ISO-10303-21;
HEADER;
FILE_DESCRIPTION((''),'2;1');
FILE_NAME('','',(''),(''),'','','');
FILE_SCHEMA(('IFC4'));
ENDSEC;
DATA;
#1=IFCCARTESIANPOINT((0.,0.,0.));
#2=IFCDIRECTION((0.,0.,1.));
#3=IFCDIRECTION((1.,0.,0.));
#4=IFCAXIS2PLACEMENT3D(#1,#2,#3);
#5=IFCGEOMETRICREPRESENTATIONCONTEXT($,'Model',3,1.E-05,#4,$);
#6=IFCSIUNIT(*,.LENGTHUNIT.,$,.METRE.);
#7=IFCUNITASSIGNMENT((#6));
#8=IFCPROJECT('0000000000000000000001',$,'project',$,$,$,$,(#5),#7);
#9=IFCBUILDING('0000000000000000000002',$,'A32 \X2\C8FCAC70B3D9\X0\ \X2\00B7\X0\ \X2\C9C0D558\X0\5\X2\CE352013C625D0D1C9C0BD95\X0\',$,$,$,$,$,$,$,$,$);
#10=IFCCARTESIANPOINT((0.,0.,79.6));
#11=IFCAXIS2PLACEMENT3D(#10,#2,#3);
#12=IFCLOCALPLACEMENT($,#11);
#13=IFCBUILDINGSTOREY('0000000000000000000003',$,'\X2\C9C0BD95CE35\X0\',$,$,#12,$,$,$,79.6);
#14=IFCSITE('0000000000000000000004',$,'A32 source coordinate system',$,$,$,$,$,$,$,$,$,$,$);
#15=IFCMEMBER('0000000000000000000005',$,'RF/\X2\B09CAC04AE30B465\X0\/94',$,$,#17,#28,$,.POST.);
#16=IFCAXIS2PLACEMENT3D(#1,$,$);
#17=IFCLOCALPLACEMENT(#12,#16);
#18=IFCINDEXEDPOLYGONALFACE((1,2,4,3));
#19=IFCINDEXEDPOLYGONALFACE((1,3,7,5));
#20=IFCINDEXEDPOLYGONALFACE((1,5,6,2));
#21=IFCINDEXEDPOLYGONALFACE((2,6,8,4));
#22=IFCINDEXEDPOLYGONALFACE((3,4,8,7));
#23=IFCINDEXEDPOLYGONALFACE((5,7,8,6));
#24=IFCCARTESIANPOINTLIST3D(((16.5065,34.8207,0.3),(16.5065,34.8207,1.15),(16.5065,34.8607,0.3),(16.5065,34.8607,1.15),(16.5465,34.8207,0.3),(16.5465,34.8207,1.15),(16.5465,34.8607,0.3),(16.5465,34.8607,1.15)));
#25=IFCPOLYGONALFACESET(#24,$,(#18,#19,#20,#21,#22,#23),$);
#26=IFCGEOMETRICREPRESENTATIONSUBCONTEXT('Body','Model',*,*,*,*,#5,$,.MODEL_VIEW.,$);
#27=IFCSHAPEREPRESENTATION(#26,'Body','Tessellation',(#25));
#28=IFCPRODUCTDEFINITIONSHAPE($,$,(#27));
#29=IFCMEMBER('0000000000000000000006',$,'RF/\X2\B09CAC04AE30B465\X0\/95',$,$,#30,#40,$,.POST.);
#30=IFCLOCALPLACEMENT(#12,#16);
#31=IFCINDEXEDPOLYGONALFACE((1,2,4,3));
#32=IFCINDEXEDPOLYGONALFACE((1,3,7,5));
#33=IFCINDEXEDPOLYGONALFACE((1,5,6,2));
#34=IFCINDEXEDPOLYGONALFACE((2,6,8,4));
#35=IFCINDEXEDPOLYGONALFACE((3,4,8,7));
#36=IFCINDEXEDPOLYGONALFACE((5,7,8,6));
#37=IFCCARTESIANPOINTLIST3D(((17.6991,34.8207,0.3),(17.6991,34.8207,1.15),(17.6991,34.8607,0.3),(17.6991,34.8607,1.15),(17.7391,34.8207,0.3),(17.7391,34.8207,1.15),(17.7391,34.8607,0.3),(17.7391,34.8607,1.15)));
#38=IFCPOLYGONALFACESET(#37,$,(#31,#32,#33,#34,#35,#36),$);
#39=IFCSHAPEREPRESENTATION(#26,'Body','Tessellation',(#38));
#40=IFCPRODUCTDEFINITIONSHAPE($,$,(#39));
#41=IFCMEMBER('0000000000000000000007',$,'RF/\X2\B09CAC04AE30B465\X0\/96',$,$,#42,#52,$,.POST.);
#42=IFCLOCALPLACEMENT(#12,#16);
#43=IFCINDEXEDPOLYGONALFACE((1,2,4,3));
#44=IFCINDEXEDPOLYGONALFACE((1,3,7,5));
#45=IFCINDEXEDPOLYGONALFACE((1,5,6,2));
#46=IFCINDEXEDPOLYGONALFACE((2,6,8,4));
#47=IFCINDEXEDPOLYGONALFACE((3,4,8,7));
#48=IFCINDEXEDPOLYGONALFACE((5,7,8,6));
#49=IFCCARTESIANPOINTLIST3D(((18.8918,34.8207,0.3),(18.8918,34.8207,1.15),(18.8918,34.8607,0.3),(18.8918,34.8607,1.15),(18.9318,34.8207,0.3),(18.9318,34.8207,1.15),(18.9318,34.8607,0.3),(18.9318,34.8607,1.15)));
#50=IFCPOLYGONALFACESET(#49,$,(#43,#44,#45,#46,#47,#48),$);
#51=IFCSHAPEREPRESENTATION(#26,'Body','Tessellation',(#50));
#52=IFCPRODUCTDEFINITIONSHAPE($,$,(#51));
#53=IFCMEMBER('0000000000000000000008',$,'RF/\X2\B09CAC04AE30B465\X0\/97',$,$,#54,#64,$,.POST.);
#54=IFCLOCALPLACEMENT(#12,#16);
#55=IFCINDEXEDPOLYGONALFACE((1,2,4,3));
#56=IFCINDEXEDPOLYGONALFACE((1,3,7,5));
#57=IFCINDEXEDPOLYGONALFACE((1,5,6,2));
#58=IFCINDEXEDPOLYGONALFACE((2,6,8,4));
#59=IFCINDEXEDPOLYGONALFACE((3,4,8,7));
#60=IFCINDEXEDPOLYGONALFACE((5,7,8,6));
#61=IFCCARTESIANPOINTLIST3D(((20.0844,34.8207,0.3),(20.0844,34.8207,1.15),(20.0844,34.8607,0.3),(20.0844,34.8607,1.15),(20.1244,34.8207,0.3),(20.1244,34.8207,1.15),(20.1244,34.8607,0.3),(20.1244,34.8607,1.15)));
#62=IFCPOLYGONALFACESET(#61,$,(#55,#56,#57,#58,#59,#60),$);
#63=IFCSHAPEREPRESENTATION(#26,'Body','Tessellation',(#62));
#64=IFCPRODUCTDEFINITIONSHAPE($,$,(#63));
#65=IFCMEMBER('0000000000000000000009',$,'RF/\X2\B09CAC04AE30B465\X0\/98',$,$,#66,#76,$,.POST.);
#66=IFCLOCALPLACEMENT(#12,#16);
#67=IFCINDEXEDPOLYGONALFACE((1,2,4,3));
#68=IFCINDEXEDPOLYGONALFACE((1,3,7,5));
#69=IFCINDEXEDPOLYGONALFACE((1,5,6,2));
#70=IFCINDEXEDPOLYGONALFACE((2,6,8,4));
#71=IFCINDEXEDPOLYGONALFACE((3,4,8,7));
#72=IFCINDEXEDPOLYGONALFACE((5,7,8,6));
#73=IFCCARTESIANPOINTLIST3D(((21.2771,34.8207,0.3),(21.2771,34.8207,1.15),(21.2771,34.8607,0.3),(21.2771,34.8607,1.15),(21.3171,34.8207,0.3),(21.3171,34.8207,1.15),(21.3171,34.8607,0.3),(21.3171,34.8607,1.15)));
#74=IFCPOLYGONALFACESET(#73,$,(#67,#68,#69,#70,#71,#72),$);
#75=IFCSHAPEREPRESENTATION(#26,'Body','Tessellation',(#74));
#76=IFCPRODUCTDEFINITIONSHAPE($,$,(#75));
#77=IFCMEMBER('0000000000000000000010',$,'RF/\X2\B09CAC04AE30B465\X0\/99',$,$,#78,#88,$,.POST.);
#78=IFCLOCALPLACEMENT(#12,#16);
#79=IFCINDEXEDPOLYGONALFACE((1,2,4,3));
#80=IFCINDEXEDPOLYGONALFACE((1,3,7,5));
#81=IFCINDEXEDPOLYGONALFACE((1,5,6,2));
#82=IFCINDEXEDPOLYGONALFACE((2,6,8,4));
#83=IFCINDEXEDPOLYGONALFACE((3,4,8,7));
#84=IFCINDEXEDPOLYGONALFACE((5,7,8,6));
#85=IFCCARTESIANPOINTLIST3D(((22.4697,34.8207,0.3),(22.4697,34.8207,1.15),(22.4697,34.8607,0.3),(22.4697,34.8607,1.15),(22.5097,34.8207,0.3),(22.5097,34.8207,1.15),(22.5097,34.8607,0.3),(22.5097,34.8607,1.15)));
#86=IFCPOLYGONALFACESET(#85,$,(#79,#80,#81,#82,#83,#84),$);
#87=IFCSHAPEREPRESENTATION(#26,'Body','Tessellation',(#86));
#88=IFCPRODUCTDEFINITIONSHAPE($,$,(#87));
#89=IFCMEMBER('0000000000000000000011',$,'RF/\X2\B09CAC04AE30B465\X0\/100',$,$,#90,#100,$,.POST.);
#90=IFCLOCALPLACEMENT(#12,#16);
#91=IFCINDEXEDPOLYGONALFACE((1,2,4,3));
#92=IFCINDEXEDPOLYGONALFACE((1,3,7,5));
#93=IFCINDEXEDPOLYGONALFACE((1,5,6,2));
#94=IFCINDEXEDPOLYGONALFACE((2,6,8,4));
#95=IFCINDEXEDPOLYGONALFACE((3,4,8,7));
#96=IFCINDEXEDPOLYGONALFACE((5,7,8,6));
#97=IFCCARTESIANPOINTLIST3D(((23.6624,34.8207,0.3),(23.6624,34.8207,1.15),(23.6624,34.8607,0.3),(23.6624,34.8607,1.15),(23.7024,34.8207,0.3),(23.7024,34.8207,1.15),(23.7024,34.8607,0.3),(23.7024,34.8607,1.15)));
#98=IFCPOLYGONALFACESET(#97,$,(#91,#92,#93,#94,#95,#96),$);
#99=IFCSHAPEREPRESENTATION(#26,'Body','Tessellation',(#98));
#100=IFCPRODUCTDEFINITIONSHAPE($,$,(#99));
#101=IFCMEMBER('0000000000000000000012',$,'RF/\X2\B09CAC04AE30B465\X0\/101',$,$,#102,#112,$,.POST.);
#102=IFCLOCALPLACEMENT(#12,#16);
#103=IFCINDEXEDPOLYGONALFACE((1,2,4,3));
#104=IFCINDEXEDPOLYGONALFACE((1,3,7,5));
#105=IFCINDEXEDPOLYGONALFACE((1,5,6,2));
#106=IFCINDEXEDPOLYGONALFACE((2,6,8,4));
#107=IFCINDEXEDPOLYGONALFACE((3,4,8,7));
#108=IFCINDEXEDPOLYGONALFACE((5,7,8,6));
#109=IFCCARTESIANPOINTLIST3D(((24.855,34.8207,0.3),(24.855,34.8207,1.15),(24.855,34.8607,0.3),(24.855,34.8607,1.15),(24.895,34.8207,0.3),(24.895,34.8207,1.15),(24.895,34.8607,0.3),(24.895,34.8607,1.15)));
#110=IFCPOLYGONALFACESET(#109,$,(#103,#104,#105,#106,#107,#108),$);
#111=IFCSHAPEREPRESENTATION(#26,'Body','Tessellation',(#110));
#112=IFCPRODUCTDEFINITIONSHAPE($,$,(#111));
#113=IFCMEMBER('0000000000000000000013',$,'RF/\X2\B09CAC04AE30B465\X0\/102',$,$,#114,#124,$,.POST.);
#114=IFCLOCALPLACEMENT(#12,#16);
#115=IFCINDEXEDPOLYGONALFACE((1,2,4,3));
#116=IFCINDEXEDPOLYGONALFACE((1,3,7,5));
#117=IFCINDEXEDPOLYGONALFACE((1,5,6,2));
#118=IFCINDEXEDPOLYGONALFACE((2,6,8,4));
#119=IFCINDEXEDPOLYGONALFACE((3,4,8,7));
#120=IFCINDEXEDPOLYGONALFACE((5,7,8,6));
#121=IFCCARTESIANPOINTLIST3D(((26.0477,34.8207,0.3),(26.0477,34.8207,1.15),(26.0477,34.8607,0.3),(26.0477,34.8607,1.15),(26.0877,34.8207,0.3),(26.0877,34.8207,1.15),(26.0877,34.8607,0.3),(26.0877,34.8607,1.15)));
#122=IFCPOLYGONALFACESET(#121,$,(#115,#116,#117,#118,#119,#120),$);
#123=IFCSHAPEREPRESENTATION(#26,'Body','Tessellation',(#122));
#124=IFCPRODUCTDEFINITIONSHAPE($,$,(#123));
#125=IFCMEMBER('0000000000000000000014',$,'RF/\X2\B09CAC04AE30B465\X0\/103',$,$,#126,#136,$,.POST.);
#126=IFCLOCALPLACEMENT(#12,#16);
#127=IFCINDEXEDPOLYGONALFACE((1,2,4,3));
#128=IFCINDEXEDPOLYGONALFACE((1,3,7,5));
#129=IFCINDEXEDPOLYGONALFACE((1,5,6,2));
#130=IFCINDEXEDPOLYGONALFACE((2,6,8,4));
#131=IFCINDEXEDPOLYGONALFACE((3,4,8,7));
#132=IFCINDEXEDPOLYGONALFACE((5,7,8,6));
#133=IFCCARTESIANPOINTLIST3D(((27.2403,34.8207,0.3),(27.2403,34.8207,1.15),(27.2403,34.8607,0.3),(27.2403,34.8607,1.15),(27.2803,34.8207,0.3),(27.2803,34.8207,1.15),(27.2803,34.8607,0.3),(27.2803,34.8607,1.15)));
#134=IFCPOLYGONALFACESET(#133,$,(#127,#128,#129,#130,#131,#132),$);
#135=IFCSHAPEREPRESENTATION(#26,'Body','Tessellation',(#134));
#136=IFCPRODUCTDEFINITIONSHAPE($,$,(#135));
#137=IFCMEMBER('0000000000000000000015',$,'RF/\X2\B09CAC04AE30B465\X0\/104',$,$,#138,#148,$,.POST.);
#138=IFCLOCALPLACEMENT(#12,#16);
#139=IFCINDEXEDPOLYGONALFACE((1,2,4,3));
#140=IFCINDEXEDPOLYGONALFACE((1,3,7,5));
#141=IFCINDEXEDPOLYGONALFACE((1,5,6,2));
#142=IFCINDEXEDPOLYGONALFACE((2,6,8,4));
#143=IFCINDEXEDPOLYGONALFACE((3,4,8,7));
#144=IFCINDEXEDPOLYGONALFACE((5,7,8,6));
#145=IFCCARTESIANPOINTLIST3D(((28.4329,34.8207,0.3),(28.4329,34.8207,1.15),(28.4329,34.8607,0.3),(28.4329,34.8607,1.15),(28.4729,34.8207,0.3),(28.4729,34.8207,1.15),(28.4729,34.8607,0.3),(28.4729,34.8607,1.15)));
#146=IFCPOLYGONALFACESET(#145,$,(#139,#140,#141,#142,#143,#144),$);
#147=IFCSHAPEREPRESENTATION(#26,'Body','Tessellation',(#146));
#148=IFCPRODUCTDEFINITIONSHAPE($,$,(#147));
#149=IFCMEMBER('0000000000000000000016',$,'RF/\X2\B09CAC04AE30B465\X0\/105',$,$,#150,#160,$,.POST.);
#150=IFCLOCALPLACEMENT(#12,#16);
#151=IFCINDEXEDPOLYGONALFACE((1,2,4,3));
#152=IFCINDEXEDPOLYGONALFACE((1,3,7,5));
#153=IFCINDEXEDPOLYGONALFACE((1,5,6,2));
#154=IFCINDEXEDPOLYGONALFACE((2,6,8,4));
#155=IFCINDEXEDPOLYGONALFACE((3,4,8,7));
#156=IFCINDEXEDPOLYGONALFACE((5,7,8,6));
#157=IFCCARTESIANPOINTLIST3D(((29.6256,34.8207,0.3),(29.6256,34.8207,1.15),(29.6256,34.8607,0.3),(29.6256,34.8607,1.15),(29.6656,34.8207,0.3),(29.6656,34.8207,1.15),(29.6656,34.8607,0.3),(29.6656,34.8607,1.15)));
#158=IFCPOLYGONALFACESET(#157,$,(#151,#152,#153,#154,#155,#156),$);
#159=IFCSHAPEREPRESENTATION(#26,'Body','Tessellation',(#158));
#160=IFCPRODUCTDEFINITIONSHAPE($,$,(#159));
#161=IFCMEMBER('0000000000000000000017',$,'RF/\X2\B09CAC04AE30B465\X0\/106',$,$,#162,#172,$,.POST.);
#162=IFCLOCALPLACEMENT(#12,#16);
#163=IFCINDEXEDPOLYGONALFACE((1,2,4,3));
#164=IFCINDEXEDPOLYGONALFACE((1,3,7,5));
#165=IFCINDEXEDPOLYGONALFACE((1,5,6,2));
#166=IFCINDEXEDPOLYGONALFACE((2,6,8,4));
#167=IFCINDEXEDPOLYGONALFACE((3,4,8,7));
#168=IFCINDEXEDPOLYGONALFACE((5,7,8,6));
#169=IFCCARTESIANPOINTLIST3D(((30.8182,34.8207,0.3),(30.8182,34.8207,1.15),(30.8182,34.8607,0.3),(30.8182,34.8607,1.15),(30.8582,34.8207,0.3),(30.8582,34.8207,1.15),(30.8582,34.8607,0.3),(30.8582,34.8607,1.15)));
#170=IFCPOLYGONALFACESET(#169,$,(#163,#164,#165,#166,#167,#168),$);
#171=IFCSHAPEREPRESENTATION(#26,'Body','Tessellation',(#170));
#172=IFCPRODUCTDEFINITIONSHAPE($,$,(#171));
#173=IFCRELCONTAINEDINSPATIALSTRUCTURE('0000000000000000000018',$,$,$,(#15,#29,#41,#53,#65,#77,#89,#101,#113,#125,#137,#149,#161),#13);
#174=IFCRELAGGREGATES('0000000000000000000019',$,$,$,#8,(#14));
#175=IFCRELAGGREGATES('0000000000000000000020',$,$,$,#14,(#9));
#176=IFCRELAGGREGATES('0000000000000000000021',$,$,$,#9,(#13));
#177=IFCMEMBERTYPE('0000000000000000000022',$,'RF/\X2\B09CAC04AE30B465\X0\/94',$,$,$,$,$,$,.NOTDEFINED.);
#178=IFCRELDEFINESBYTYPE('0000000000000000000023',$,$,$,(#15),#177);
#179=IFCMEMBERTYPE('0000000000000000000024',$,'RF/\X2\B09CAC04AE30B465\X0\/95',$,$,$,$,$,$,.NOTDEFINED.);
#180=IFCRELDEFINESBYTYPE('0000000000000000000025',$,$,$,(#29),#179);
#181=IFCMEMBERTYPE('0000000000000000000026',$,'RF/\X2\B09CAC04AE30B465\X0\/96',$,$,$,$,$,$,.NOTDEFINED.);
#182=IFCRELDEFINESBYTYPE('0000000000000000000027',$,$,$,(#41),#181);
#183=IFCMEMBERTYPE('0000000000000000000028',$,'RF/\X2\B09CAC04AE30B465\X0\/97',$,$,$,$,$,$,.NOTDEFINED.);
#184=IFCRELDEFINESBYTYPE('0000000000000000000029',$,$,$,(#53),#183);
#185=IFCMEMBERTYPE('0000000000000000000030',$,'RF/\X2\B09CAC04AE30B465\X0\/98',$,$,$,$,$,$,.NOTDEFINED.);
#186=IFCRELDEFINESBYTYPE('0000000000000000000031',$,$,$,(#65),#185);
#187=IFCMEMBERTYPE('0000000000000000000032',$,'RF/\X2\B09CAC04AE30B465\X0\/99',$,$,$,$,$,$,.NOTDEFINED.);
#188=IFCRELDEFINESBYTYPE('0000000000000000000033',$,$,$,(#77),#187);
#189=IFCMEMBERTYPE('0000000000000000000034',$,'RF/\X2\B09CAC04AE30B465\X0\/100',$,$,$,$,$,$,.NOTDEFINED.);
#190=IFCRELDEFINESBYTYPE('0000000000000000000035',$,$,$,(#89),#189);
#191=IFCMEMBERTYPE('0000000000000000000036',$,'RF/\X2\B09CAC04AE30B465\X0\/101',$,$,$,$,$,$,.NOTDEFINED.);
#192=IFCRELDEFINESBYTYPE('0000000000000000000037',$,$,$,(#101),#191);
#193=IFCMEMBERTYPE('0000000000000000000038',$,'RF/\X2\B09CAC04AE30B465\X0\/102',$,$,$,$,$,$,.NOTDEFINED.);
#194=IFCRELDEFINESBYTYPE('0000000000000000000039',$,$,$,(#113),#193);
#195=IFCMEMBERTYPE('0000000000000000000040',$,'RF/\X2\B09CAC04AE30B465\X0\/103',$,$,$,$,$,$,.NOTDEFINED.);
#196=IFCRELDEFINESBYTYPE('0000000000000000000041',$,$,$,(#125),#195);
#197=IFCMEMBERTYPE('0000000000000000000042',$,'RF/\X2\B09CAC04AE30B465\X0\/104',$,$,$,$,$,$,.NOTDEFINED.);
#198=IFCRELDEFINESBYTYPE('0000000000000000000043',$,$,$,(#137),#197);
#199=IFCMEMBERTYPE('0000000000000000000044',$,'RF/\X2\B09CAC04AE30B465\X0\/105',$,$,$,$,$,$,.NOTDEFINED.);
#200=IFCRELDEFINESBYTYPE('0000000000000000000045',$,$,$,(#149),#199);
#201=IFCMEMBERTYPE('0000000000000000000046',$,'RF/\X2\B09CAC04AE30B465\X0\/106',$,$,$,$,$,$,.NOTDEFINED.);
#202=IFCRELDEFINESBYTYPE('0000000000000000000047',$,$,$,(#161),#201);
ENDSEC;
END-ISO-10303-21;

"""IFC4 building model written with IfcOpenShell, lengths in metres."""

from ifc_helpers import new_model, si_unit, frame, origin, origin_with_axes, place, context, subcontext, project, spatial, polyline, outline, extrude, source, transform, mapped, type_object, type_shapes, element, save


model = new_model("IFC4")

# Units and contexts
model_context = context("Model", 3, precision=1e-05, world=origin_with_axes())
body_context = subcontext(model_context, "Body", "Model", "MODEL_VIEW")
ifc_project = project(units=[si_unit("LENGTHUNIT", "METRE")], contexts=[model_context])

# Site, building, storey
site = spatial("IfcSite", under=ifc_project, Name="A32 source coordinate system")
building = spatial("IfcBuilding", under=site, Name="A32 주거동 · 지하5층–옥탑지붕")
storey_placement = place(None, frame((0.0, 0.0, 79.6), z_axis=(0.0, 0.0, 1.0), x_axis=(1.0, 0.0, 0.0)))
storey = spatial("IfcBuildingStorey", under=building, at=storey_placement, Name="지붕층", Elevation=79.6)

# Members
member_type_1 = type_object("IfcMemberType", Name="RF/난간기둥/94", PredefinedType="NOTDEFINED")
shared_shape_1 = source(origin(), body_context, "Body", "SweptSolid", [
    extrude(outline(polyline([(16.5465, 34.8207), (16.5065, 34.8207), (16.5065, 34.8607), (16.5465, 34.8607), (16.5465, 34.8207)])), frame((0.0, 0.0, 0.3)), (0.0, 0.0, 1.0), 0.85),
])
type_shapes(member_type_1, [shared_shape_1])
member_1_placement = place(storey_placement, origin_with_axes())
element("IfcMember", 1, at=member_1_placement, inside=storey, type_object=member_type_1, Name="RF/난간기둥/94", PredefinedType="POST", context=body_context, shape_type="MappedRepresentation", body=[
    mapped(shared_shape_1, transform((0.0, 0.0, 0.0), scale=1.0)),
])
member_type_2 = type_object("IfcMemberType", Name="RF/난간기둥/95", PredefinedType="NOTDEFINED")
shared_shape_2 = source(origin(), body_context, "Body", "SweptSolid", [
    extrude(outline(polyline([(17.7391, 34.8207), (17.6991, 34.8207), (17.6991, 34.8607), (17.7391, 34.8607), (17.7391, 34.8207)])), frame((0.0, 0.0, 0.3)), (0.0, 0.0, 1.0), 0.85),
])
type_shapes(member_type_2, [shared_shape_2])
member_2_placement = place(storey_placement, origin_with_axes())
element("IfcMember", 2, at=member_2_placement, inside=storey, type_object=member_type_2, Name="RF/난간기둥/95", PredefinedType="POST", context=body_context, shape_type="MappedRepresentation", body=[
    mapped(shared_shape_2, transform((0.0, 0.0, 0.0), scale=1.0)),
])
member_type_3 = type_object("IfcMemberType", Name="RF/난간기둥/96", PredefinedType="NOTDEFINED")
shared_shape_3 = source(origin(), body_context, "Body", "SweptSolid", [
    extrude(outline(polyline([(18.9318, 34.8207), (18.8918, 34.8207), (18.8918, 34.8607), (18.9318, 34.8607), (18.9318, 34.8207)])), frame((0.0, 0.0, 0.3)), (0.0, 0.0, 1.0), 0.85),
])
type_shapes(member_type_3, [shared_shape_3])
member_3_placement = place(storey_placement, origin_with_axes())
element("IfcMember", 3, at=member_3_placement, inside=storey, type_object=member_type_3, Name="RF/난간기둥/96", PredefinedType="POST", context=body_context, shape_type="MappedRepresentation", body=[
    mapped(shared_shape_3, transform((0.0, 0.0, 0.0), scale=1.0)),
])
member_type_4 = type_object("IfcMemberType", Name="RF/난간기둥/97", PredefinedType="NOTDEFINED")
shared_shape_4 = source(origin(), body_context, "Body", "SweptSolid", [
    extrude(outline(polyline([(20.1244, 34.8207), (20.0844, 34.8207), (20.0844, 34.8607), (20.1244, 34.8607), (20.1244, 34.8207)])), frame((0.0, 0.0, 0.3)), (0.0, 0.0, 1.0), 0.85),
])
type_shapes(member_type_4, [shared_shape_4])
member_4_placement = place(storey_placement, origin_with_axes())
element("IfcMember", 4, at=member_4_placement, inside=storey, type_object=member_type_4, Name="RF/난간기둥/97", PredefinedType="POST", context=body_context, shape_type="MappedRepresentation", body=[
    mapped(shared_shape_4, transform((0.0, 0.0, 0.0), scale=1.0)),
])
member_type_5 = type_object("IfcMemberType", Name="RF/난간기둥/98", PredefinedType="NOTDEFINED")
shared_shape_5 = source(origin(), body_context, "Body", "SweptSolid", [
    extrude(outline(polyline([(21.3171, 34.8207), (21.2771, 34.8207), (21.2771, 34.8607), (21.3171, 34.8607), (21.3171, 34.8207)])), frame((0.0, 0.0, 0.3)), (0.0, 0.0, 1.0), 0.85),
])
type_shapes(member_type_5, [shared_shape_5])
member_5_placement = place(storey_placement, origin_with_axes())
element("IfcMember", 5, at=member_5_placement, inside=storey, type_object=member_type_5, Name="RF/난간기둥/98", PredefinedType="POST", context=body_context, shape_type="MappedRepresentation", body=[
    mapped(shared_shape_5, transform((0.0, 0.0, 0.0), scale=1.0)),
])
member_type_6 = type_object("IfcMemberType", Name="RF/난간기둥/99", PredefinedType="NOTDEFINED")
shared_shape_6 = source(origin(), body_context, "Body", "SweptSolid", [
    extrude(outline(polyline([(22.5097, 34.8207), (22.4697, 34.8207), (22.4697, 34.8607), (22.5097, 34.8607), (22.5097, 34.8207)])), frame((0.0, 0.0, 0.3)), (0.0, 0.0, 1.0), 0.85),
])
type_shapes(member_type_6, [shared_shape_6])
member_6_placement = place(storey_placement, origin_with_axes())
element("IfcMember", 6, at=member_6_placement, inside=storey, type_object=member_type_6, Name="RF/난간기둥/99", PredefinedType="POST", context=body_context, shape_type="MappedRepresentation", body=[
    mapped(shared_shape_6, transform((0.0, 0.0, 0.0), scale=1.0)),
])
member_type_7 = type_object("IfcMemberType", Name="RF/난간기둥/100", PredefinedType="NOTDEFINED")
shared_shape_7 = source(origin(), body_context, "Body", "SweptSolid", [
    extrude(outline(polyline([(23.7024, 34.8207), (23.6624, 34.8207), (23.6624, 34.8607), (23.7024, 34.8607), (23.7024, 34.8207)])), frame((0.0, 0.0, 0.3)), (0.0, 0.0, 1.0), 0.85),
])
type_shapes(member_type_7, [shared_shape_7])
member_7_placement = place(storey_placement, origin_with_axes())
element("IfcMember", 7, at=member_7_placement, inside=storey, type_object=member_type_7, Name="RF/난간기둥/100", PredefinedType="POST", context=body_context, shape_type="MappedRepresentation", body=[
    mapped(shared_shape_7, transform((0.0, 0.0, 0.0), scale=1.0)),
])
member_type_8 = type_object("IfcMemberType", Name="RF/난간기둥/101", PredefinedType="NOTDEFINED")
shared_shape_8 = source(origin(), body_context, "Body", "SweptSolid", [
    extrude(outline(polyline([(24.895, 34.8207), (24.855, 34.8207), (24.855, 34.8607), (24.895, 34.8607), (24.895, 34.8207)])), frame((0.0, 0.0, 0.3)), (0.0, 0.0, 1.0), 0.85),
])
type_shapes(member_type_8, [shared_shape_8])
member_8_placement = place(storey_placement, origin_with_axes())
element("IfcMember", 8, at=member_8_placement, inside=storey, type_object=member_type_8, Name="RF/난간기둥/101", PredefinedType="POST", context=body_context, shape_type="MappedRepresentation", body=[
    mapped(shared_shape_8, transform((0.0, 0.0, 0.0), scale=1.0)),
])
member_type_9 = type_object("IfcMemberType", Name="RF/난간기둥/102", PredefinedType="NOTDEFINED")
shared_shape_9 = source(origin(), body_context, "Body", "SweptSolid", [
    extrude(outline(polyline([(26.0877, 34.8207), (26.0477, 34.8207), (26.0477, 34.8607), (26.0877, 34.8607), (26.0877, 34.8207)])), frame((0.0, 0.0, 0.3)), (0.0, 0.0, 1.0), 0.85),
])
type_shapes(member_type_9, [shared_shape_9])
member_9_placement = place(storey_placement, origin_with_axes())
element("IfcMember", 9, at=member_9_placement, inside=storey, type_object=member_type_9, Name="RF/난간기둥/102", PredefinedType="POST", context=body_context, shape_type="MappedRepresentation", body=[
    mapped(shared_shape_9, transform((0.0, 0.0, 0.0), scale=1.0)),
])
member_type_10 = type_object("IfcMemberType", Name="RF/난간기둥/103", PredefinedType="NOTDEFINED")
shared_shape_10 = source(origin(), body_context, "Body", "SweptSolid", [
    extrude(outline(polyline([(27.2803, 34.8207), (27.2403, 34.8207), (27.2403, 34.8607), (27.2803, 34.8607), (27.2803, 34.8207)])), frame((0.0, 0.0, 0.3)), (0.0, 0.0, 1.0), 0.85),
])
type_shapes(member_type_10, [shared_shape_10])
member_10_placement = place(storey_placement, origin_with_axes())
element("IfcMember", 10, at=member_10_placement, inside=storey, type_object=member_type_10, Name="RF/난간기둥/103", PredefinedType="POST", context=body_context, shape_type="MappedRepresentation", body=[
    mapped(shared_shape_10, transform((0.0, 0.0, 0.0), scale=1.0)),
])
member_type_11 = type_object("IfcMemberType", Name="RF/난간기둥/104", PredefinedType="NOTDEFINED")
shared_shape_11 = source(origin(), body_context, "Body", "SweptSolid", [
    extrude(outline(polyline([(28.4729, 34.8207), (28.4329, 34.8207), (28.4329, 34.8607), (28.4729, 34.8607), (28.4729, 34.8207)])), frame((0.0, 0.0, 0.3)), (0.0, 0.0, 1.0), 0.85),
])
type_shapes(member_type_11, [shared_shape_11])
member_11_placement = place(storey_placement, origin_with_axes())
element("IfcMember", 11, at=member_11_placement, inside=storey, type_object=member_type_11, Name="RF/난간기둥/104", PredefinedType="POST", context=body_context, shape_type="MappedRepresentation", body=[
    mapped(shared_shape_11, transform((0.0, 0.0, 0.0), scale=1.0)),
])
member_type_12 = type_object("IfcMemberType", Name="RF/난간기둥/105", PredefinedType="NOTDEFINED")
shared_shape_12 = source(origin(), body_context, "Body", "SweptSolid", [
    extrude(outline(polyline([(29.6656, 34.8207), (29.6256, 34.8207), (29.6256, 34.8607), (29.6656, 34.8607), (29.6656, 34.8207)])), frame((0.0, 0.0, 0.3)), (0.0, 0.0, 1.0), 0.85),
])
type_shapes(member_type_12, [shared_shape_12])
member_12_placement = place(storey_placement, origin_with_axes())
element("IfcMember", 12, at=member_12_placement, inside=storey, type_object=member_type_12, Name="RF/난간기둥/105", PredefinedType="POST", context=body_context, shape_type="MappedRepresentation", body=[
    mapped(shared_shape_12, transform((0.0, 0.0, 0.0), scale=1.0)),
])
member_type_13 = type_object("IfcMemberType", Name="RF/난간기둥/106", PredefinedType="NOTDEFINED")
shared_shape_13 = source(origin(), body_context, "Body", "SweptSolid", [
    extrude(outline(polyline([(30.8582, 34.8207), (30.8182, 34.8207), (30.8182, 34.8607), (30.8582, 34.8607), (30.8582, 34.8207)])), frame((0.0, 0.0, 0.3)), (0.0, 0.0, 1.0), 0.85),
])
type_shapes(member_type_13, [shared_shape_13])
member_13_placement = place(storey_placement, origin_with_axes())
element("IfcMember", 13, at=member_13_placement, inside=storey, type_object=member_type_13, Name="RF/난간기둥/106", PredefinedType="POST", context=body_context, shape_type="MappedRepresentation", body=[
    mapped(shared_shape_13, transform((0.0, 0.0, 0.0), scale=1.0)),
])

save(model, "model.ifc")
